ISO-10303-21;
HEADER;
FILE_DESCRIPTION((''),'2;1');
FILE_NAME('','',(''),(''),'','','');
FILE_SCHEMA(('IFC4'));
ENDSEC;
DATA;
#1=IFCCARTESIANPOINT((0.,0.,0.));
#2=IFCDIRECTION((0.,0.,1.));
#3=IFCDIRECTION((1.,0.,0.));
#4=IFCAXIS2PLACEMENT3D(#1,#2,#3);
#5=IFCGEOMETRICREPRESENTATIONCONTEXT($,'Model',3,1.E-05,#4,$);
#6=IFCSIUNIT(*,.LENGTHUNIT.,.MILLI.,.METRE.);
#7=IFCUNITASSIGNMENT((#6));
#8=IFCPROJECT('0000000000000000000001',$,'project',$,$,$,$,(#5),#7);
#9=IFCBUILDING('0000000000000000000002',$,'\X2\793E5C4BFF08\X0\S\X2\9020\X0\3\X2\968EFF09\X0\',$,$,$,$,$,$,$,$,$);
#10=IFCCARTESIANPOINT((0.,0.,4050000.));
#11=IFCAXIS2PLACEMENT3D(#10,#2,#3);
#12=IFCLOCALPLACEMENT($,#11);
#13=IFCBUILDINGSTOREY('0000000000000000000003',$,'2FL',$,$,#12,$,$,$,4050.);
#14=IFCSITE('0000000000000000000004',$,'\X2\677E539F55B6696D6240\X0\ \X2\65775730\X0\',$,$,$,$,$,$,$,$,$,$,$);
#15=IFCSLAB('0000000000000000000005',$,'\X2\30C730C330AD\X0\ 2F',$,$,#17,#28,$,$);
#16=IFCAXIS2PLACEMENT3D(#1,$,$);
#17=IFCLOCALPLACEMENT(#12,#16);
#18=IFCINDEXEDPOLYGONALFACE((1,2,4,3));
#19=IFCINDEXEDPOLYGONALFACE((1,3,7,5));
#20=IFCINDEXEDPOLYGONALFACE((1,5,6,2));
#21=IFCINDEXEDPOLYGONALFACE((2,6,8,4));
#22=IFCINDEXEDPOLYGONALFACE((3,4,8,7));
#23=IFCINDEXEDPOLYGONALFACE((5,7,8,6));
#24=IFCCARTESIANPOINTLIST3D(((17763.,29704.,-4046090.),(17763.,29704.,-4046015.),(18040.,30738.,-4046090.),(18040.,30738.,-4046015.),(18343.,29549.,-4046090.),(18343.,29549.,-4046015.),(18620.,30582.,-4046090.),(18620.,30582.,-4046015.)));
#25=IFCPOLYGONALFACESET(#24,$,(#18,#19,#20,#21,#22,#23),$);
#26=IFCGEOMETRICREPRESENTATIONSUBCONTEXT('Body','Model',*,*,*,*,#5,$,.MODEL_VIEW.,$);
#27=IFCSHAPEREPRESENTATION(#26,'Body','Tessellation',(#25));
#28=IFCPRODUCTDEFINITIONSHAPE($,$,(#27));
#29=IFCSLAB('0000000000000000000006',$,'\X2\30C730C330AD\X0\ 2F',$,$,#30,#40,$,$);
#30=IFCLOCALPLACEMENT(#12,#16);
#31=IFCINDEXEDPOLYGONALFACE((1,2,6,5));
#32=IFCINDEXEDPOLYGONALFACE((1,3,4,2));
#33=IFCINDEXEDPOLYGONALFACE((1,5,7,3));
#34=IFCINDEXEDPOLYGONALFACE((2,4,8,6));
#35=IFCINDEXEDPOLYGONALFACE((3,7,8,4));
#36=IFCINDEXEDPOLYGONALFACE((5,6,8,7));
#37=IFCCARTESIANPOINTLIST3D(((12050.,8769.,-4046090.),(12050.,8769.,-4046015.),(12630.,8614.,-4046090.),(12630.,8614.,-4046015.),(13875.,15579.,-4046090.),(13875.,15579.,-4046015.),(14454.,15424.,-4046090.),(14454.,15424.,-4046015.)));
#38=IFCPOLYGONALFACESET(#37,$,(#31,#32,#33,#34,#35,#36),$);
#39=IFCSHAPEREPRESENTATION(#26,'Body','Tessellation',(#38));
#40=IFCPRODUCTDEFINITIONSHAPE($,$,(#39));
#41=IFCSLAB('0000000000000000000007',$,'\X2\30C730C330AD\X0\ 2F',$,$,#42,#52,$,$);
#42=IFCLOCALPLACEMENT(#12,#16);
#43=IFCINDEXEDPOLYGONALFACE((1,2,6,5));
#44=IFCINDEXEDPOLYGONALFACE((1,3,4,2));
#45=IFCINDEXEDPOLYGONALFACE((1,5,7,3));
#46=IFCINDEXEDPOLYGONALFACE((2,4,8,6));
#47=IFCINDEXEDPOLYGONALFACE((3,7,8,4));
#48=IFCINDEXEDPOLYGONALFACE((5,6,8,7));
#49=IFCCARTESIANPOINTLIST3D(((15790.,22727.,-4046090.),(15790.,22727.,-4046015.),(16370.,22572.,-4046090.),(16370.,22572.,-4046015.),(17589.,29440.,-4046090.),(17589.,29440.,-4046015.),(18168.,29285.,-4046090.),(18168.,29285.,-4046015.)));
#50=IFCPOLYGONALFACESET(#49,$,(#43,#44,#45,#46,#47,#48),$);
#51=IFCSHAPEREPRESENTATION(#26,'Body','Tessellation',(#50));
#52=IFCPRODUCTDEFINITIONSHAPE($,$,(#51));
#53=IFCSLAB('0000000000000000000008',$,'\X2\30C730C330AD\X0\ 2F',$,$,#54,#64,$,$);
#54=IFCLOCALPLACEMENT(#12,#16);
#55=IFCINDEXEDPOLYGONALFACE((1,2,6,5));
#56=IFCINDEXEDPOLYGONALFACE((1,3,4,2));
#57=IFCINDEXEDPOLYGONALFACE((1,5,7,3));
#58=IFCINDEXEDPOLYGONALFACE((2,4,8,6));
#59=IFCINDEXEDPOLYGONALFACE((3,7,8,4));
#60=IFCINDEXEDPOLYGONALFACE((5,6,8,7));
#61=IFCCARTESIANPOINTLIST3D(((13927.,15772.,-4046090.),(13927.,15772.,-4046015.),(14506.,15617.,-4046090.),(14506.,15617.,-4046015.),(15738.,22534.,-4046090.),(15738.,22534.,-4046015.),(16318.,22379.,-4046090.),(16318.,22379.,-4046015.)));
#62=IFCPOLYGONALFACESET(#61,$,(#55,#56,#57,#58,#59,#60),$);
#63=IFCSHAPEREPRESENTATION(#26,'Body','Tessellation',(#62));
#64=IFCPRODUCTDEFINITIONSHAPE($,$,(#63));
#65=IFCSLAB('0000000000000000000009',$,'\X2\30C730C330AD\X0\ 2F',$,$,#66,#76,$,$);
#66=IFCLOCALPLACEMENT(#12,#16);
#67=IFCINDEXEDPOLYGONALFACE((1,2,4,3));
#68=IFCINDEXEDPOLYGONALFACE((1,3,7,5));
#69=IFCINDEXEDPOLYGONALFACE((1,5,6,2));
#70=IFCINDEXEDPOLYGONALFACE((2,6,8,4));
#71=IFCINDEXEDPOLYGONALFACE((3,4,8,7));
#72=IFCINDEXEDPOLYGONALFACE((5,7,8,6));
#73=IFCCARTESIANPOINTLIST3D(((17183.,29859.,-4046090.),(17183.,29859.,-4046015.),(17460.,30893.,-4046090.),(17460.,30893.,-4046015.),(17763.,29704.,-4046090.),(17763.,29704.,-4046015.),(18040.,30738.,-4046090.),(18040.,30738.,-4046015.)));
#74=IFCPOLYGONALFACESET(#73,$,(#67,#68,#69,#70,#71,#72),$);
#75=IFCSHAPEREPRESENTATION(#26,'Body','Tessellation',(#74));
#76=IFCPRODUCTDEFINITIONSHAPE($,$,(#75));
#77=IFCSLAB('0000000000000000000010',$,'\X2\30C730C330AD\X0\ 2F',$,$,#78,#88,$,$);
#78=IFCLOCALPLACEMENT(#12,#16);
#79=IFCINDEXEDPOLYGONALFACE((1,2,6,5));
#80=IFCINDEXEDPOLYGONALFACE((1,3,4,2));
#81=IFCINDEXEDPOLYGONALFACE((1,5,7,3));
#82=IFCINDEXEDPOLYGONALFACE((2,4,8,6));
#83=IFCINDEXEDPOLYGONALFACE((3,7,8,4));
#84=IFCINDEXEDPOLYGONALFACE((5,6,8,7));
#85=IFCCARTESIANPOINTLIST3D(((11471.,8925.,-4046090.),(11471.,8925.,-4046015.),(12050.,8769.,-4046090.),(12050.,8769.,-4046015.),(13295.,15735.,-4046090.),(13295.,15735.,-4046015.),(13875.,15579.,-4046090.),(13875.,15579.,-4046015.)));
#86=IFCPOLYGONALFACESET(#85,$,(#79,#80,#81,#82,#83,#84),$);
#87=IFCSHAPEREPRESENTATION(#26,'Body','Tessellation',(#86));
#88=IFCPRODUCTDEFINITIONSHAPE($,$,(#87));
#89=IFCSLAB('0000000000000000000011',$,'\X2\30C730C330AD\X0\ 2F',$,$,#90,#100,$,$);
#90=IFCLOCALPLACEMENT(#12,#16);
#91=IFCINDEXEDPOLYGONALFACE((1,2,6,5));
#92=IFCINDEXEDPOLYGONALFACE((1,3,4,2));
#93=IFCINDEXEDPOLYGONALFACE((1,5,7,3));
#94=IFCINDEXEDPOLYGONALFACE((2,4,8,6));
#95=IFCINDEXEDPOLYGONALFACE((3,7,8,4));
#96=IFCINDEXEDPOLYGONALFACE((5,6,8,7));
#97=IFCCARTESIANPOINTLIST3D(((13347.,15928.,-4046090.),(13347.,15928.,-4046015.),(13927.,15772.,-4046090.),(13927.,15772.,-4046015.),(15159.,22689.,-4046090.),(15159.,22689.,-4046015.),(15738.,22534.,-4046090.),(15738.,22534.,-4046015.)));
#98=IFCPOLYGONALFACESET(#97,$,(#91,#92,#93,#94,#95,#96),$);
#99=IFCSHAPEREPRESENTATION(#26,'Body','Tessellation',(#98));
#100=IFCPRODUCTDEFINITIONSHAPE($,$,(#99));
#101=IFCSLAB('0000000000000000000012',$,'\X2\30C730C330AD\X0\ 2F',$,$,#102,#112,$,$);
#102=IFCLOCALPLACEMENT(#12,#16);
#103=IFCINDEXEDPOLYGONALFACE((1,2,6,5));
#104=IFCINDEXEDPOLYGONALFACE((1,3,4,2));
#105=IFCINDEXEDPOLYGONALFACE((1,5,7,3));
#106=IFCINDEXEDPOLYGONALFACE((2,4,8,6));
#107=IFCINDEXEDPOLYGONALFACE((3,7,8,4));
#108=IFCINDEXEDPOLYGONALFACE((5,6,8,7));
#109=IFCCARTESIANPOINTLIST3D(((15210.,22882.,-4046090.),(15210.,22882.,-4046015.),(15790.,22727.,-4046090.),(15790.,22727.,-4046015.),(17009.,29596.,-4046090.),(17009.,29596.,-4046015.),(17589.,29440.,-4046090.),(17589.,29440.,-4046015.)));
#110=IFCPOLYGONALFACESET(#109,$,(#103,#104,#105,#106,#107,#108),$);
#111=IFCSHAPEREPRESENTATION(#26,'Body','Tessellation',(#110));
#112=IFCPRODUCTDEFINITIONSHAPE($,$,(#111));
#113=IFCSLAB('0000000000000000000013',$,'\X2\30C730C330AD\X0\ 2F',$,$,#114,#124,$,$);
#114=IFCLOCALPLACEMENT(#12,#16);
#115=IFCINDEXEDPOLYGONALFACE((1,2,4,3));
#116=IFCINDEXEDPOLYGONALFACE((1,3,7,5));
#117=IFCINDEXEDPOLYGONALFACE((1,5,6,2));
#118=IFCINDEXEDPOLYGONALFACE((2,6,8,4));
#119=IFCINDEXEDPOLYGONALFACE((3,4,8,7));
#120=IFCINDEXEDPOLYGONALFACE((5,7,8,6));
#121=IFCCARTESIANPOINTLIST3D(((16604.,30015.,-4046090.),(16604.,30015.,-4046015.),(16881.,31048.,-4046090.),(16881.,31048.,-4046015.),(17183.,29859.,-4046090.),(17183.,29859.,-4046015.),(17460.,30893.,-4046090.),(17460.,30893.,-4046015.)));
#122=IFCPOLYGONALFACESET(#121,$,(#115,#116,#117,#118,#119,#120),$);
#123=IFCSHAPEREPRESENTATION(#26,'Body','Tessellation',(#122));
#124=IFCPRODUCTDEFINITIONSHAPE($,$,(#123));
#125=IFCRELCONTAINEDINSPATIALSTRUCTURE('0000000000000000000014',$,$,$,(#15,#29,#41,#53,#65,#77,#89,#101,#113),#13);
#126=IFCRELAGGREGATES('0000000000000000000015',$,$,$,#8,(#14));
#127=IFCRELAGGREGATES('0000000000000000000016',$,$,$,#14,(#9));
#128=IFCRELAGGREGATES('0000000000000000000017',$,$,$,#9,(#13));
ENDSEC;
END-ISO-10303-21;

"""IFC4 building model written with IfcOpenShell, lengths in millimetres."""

from ifc_helpers import new_model, si_unit, frame, origin, origin_with_axes, place, context, subcontext, project, spatial, polyline, outline, extrude, element, save


model = new_model("IFC4")

# Units and contexts
model_context = context("Model", 3, precision=1e-05, world=origin_with_axes())
body_context = subcontext(model_context, "Body", "Model", "MODEL_VIEW")
ifc_project = project(units=[si_unit("LENGTHUNIT", "METRE", prefix="MILLI")], contexts=[model_context])

# Site, building, storey
site = spatial("IfcSite", under=ifc_project, Name="松原営業所 敷地")
building = spatial("IfcBuilding", under=site, Name="社屋（S造3階）")
storey_placement = place(None, frame((0.0, 0.0, 4050000.0), z_axis=(0.0, 0.0, 1.0), x_axis=(1.0, 0.0, 0.0)))
storey = spatial("IfcBuildingStorey", under=building, at=storey_placement, Name="2FL", Elevation=4050.0)

# Slabs
slab_1_placement = place(storey_placement, frame((0.0, 0.0, -4046090.0), z_axis=(0.0, 0.0, 1.0), x_axis=(1.0, 0.0, 0.0)))
element("IfcSlab", 1, at=slab_1_placement, inside=storey, Name="デッキ 2F", context=body_context, shape_type="SweptSolid", body=[
    extrude(outline(polyline([(18343.0, 29549.0), (18620.0, 30582.0), (18040.0, 30738.0), (17763.0, 29704.0), (18343.0, 29549.0)])), origin(), (0.0, 0.0, 1.0), 75.0),
])
slab_2_placement = place(storey_placement, frame((0.0, 0.0, -4046090.0), z_axis=(0.0, 0.0, 1.0), x_axis=(1.0, 0.0, 0.0)))
element("IfcSlab", 2, at=slab_2_placement, inside=storey, Name="デッキ 2F", context=body_context, shape_type="SweptSolid", body=[
    extrude(outline(polyline([(12630.0, 8614.0), (14454.0, 15424.0), (13875.0, 15579.0), (12050.0, 8769.0), (12630.0, 8614.0)])), origin(), (0.0, 0.0, 1.0), 75.0),
])
slab_3_placement = place(storey_placement, frame((0.0, 0.0, -4046090.0), z_axis=(0.0, 0.0, 1.0), x_axis=(1.0, 0.0, 0.0)))
element("IfcSlab", 3, at=slab_3_placement, inside=storey, Name="デッキ 2F", context=body_context, shape_type="SweptSolid", body=[
    extrude(outline(polyline([(16370.0, 22572.0), (18168.0, 29285.0), (17589.0, 29440.0), (15790.0, 22727.0), (16370.0, 22572.0)])), origin(), (0.0, 0.0, 1.0), 75.0),
])
slab_4_placement = place(storey_placement, frame((0.0, 0.0, -4046090.0), z_axis=(0.0, 0.0, 1.0), x_axis=(1.0, 0.0, 0.0)))
element("IfcSlab", 4, at=slab_4_placement, inside=storey, Name="デッキ 2F", context=body_context, shape_type="SweptSolid", body=[
    extrude(outline(polyline([(14506.0, 15617.0), (16318.0, 22379.0), (15738.0, 22534.0), (13927.0, 15772.0), (14506.0, 15617.0)])), origin(), (0.0, 0.0, 1.0), 75.0),
])
slab_5_placement = place(storey_placement, frame((0.0, 0.0, -4046090.0), z_axis=(0.0, 0.0, 1.0), x_axis=(1.0, 0.0, 0.0)))
element("IfcSlab", 5, at=slab_5_placement, inside=storey, Name="デッキ 2F", context=body_context, shape_type="SweptSolid", body=[
    extrude(outline(polyline([(17763.0, 29704.0), (18040.0, 30738.0), (17460.0, 30893.0), (17183.0, 29859.0), (17763.0, 29704.0)])), origin(), (0.0, 0.0, 1.0), 75.0),
])
slab_6_placement = place(storey_placement, frame((0.0, 0.0, -4046090.0), z_axis=(0.0, 0.0, 1.0), x_axis=(1.0, 0.0, 0.0)))
element("IfcSlab", 6, at=slab_6_placement, inside=storey, Name="デッキ 2F", context=body_context, shape_type="SweptSolid", body=[
    extrude(outline(polyline([(12050.0, 8769.0), (13875.0, 15579.0), (13295.0, 15735.0), (11471.0, 8925.0), (12050.0, 8769.0)])), origin(), (0.0, 0.0, 1.0), 75.0),
])
slab_7_placement = place(storey_placement, frame((0.0, 0.0, -4046090.0), z_axis=(0.0, 0.0, 1.0), x_axis=(1.0, 0.0, 0.0)))
element("IfcSlab", 7, at=slab_7_placement, inside=storey, Name="デッキ 2F", context=body_context, shape_type="SweptSolid", body=[
    extrude(outline(polyline([(13927.0, 15772.0), (15738.0, 22534.0), (15159.0, 22689.0), (13347.0, 15928.0), (13927.0, 15772.0)])), origin(), (0.0, 0.0, 1.0), 75.0),
])
slab_8_placement = place(storey_placement, frame((0.0, 0.0, -4046090.0), z_axis=(0.0, 0.0, 1.0), x_axis=(1.0, 0.0, 0.0)))
element("IfcSlab", 8, at=slab_8_placement, inside=storey, Name="デッキ 2F", context=body_context, shape_type="SweptSolid", body=[
    extrude(outline(polyline([(15790.0, 22727.0), (17589.0, 29440.0), (17009.0, 29596.0), (15210.0, 22882.0), (15790.0, 22727.0)])), origin(), (0.0, 0.0, 1.0), 75.0),
])
slab_9_placement = place(storey_placement, frame((0.0, 0.0, -4046090.0), z_axis=(0.0, 0.0, 1.0), x_axis=(1.0, 0.0, 0.0)))
element("IfcSlab", 9, at=slab_9_placement, inside=storey, Name="デッキ 2F", context=body_context, shape_type="SweptSolid", body=[
    extrude(outline(polyline([(17183.0, 29859.0), (17460.0, 30893.0), (16881.0, 31048.0), (16604.0, 30015.0), (17183.0, 29859.0)])), origin(), (0.0, 0.0, 1.0), 75.0),
])

save(model, "model.ifc")
